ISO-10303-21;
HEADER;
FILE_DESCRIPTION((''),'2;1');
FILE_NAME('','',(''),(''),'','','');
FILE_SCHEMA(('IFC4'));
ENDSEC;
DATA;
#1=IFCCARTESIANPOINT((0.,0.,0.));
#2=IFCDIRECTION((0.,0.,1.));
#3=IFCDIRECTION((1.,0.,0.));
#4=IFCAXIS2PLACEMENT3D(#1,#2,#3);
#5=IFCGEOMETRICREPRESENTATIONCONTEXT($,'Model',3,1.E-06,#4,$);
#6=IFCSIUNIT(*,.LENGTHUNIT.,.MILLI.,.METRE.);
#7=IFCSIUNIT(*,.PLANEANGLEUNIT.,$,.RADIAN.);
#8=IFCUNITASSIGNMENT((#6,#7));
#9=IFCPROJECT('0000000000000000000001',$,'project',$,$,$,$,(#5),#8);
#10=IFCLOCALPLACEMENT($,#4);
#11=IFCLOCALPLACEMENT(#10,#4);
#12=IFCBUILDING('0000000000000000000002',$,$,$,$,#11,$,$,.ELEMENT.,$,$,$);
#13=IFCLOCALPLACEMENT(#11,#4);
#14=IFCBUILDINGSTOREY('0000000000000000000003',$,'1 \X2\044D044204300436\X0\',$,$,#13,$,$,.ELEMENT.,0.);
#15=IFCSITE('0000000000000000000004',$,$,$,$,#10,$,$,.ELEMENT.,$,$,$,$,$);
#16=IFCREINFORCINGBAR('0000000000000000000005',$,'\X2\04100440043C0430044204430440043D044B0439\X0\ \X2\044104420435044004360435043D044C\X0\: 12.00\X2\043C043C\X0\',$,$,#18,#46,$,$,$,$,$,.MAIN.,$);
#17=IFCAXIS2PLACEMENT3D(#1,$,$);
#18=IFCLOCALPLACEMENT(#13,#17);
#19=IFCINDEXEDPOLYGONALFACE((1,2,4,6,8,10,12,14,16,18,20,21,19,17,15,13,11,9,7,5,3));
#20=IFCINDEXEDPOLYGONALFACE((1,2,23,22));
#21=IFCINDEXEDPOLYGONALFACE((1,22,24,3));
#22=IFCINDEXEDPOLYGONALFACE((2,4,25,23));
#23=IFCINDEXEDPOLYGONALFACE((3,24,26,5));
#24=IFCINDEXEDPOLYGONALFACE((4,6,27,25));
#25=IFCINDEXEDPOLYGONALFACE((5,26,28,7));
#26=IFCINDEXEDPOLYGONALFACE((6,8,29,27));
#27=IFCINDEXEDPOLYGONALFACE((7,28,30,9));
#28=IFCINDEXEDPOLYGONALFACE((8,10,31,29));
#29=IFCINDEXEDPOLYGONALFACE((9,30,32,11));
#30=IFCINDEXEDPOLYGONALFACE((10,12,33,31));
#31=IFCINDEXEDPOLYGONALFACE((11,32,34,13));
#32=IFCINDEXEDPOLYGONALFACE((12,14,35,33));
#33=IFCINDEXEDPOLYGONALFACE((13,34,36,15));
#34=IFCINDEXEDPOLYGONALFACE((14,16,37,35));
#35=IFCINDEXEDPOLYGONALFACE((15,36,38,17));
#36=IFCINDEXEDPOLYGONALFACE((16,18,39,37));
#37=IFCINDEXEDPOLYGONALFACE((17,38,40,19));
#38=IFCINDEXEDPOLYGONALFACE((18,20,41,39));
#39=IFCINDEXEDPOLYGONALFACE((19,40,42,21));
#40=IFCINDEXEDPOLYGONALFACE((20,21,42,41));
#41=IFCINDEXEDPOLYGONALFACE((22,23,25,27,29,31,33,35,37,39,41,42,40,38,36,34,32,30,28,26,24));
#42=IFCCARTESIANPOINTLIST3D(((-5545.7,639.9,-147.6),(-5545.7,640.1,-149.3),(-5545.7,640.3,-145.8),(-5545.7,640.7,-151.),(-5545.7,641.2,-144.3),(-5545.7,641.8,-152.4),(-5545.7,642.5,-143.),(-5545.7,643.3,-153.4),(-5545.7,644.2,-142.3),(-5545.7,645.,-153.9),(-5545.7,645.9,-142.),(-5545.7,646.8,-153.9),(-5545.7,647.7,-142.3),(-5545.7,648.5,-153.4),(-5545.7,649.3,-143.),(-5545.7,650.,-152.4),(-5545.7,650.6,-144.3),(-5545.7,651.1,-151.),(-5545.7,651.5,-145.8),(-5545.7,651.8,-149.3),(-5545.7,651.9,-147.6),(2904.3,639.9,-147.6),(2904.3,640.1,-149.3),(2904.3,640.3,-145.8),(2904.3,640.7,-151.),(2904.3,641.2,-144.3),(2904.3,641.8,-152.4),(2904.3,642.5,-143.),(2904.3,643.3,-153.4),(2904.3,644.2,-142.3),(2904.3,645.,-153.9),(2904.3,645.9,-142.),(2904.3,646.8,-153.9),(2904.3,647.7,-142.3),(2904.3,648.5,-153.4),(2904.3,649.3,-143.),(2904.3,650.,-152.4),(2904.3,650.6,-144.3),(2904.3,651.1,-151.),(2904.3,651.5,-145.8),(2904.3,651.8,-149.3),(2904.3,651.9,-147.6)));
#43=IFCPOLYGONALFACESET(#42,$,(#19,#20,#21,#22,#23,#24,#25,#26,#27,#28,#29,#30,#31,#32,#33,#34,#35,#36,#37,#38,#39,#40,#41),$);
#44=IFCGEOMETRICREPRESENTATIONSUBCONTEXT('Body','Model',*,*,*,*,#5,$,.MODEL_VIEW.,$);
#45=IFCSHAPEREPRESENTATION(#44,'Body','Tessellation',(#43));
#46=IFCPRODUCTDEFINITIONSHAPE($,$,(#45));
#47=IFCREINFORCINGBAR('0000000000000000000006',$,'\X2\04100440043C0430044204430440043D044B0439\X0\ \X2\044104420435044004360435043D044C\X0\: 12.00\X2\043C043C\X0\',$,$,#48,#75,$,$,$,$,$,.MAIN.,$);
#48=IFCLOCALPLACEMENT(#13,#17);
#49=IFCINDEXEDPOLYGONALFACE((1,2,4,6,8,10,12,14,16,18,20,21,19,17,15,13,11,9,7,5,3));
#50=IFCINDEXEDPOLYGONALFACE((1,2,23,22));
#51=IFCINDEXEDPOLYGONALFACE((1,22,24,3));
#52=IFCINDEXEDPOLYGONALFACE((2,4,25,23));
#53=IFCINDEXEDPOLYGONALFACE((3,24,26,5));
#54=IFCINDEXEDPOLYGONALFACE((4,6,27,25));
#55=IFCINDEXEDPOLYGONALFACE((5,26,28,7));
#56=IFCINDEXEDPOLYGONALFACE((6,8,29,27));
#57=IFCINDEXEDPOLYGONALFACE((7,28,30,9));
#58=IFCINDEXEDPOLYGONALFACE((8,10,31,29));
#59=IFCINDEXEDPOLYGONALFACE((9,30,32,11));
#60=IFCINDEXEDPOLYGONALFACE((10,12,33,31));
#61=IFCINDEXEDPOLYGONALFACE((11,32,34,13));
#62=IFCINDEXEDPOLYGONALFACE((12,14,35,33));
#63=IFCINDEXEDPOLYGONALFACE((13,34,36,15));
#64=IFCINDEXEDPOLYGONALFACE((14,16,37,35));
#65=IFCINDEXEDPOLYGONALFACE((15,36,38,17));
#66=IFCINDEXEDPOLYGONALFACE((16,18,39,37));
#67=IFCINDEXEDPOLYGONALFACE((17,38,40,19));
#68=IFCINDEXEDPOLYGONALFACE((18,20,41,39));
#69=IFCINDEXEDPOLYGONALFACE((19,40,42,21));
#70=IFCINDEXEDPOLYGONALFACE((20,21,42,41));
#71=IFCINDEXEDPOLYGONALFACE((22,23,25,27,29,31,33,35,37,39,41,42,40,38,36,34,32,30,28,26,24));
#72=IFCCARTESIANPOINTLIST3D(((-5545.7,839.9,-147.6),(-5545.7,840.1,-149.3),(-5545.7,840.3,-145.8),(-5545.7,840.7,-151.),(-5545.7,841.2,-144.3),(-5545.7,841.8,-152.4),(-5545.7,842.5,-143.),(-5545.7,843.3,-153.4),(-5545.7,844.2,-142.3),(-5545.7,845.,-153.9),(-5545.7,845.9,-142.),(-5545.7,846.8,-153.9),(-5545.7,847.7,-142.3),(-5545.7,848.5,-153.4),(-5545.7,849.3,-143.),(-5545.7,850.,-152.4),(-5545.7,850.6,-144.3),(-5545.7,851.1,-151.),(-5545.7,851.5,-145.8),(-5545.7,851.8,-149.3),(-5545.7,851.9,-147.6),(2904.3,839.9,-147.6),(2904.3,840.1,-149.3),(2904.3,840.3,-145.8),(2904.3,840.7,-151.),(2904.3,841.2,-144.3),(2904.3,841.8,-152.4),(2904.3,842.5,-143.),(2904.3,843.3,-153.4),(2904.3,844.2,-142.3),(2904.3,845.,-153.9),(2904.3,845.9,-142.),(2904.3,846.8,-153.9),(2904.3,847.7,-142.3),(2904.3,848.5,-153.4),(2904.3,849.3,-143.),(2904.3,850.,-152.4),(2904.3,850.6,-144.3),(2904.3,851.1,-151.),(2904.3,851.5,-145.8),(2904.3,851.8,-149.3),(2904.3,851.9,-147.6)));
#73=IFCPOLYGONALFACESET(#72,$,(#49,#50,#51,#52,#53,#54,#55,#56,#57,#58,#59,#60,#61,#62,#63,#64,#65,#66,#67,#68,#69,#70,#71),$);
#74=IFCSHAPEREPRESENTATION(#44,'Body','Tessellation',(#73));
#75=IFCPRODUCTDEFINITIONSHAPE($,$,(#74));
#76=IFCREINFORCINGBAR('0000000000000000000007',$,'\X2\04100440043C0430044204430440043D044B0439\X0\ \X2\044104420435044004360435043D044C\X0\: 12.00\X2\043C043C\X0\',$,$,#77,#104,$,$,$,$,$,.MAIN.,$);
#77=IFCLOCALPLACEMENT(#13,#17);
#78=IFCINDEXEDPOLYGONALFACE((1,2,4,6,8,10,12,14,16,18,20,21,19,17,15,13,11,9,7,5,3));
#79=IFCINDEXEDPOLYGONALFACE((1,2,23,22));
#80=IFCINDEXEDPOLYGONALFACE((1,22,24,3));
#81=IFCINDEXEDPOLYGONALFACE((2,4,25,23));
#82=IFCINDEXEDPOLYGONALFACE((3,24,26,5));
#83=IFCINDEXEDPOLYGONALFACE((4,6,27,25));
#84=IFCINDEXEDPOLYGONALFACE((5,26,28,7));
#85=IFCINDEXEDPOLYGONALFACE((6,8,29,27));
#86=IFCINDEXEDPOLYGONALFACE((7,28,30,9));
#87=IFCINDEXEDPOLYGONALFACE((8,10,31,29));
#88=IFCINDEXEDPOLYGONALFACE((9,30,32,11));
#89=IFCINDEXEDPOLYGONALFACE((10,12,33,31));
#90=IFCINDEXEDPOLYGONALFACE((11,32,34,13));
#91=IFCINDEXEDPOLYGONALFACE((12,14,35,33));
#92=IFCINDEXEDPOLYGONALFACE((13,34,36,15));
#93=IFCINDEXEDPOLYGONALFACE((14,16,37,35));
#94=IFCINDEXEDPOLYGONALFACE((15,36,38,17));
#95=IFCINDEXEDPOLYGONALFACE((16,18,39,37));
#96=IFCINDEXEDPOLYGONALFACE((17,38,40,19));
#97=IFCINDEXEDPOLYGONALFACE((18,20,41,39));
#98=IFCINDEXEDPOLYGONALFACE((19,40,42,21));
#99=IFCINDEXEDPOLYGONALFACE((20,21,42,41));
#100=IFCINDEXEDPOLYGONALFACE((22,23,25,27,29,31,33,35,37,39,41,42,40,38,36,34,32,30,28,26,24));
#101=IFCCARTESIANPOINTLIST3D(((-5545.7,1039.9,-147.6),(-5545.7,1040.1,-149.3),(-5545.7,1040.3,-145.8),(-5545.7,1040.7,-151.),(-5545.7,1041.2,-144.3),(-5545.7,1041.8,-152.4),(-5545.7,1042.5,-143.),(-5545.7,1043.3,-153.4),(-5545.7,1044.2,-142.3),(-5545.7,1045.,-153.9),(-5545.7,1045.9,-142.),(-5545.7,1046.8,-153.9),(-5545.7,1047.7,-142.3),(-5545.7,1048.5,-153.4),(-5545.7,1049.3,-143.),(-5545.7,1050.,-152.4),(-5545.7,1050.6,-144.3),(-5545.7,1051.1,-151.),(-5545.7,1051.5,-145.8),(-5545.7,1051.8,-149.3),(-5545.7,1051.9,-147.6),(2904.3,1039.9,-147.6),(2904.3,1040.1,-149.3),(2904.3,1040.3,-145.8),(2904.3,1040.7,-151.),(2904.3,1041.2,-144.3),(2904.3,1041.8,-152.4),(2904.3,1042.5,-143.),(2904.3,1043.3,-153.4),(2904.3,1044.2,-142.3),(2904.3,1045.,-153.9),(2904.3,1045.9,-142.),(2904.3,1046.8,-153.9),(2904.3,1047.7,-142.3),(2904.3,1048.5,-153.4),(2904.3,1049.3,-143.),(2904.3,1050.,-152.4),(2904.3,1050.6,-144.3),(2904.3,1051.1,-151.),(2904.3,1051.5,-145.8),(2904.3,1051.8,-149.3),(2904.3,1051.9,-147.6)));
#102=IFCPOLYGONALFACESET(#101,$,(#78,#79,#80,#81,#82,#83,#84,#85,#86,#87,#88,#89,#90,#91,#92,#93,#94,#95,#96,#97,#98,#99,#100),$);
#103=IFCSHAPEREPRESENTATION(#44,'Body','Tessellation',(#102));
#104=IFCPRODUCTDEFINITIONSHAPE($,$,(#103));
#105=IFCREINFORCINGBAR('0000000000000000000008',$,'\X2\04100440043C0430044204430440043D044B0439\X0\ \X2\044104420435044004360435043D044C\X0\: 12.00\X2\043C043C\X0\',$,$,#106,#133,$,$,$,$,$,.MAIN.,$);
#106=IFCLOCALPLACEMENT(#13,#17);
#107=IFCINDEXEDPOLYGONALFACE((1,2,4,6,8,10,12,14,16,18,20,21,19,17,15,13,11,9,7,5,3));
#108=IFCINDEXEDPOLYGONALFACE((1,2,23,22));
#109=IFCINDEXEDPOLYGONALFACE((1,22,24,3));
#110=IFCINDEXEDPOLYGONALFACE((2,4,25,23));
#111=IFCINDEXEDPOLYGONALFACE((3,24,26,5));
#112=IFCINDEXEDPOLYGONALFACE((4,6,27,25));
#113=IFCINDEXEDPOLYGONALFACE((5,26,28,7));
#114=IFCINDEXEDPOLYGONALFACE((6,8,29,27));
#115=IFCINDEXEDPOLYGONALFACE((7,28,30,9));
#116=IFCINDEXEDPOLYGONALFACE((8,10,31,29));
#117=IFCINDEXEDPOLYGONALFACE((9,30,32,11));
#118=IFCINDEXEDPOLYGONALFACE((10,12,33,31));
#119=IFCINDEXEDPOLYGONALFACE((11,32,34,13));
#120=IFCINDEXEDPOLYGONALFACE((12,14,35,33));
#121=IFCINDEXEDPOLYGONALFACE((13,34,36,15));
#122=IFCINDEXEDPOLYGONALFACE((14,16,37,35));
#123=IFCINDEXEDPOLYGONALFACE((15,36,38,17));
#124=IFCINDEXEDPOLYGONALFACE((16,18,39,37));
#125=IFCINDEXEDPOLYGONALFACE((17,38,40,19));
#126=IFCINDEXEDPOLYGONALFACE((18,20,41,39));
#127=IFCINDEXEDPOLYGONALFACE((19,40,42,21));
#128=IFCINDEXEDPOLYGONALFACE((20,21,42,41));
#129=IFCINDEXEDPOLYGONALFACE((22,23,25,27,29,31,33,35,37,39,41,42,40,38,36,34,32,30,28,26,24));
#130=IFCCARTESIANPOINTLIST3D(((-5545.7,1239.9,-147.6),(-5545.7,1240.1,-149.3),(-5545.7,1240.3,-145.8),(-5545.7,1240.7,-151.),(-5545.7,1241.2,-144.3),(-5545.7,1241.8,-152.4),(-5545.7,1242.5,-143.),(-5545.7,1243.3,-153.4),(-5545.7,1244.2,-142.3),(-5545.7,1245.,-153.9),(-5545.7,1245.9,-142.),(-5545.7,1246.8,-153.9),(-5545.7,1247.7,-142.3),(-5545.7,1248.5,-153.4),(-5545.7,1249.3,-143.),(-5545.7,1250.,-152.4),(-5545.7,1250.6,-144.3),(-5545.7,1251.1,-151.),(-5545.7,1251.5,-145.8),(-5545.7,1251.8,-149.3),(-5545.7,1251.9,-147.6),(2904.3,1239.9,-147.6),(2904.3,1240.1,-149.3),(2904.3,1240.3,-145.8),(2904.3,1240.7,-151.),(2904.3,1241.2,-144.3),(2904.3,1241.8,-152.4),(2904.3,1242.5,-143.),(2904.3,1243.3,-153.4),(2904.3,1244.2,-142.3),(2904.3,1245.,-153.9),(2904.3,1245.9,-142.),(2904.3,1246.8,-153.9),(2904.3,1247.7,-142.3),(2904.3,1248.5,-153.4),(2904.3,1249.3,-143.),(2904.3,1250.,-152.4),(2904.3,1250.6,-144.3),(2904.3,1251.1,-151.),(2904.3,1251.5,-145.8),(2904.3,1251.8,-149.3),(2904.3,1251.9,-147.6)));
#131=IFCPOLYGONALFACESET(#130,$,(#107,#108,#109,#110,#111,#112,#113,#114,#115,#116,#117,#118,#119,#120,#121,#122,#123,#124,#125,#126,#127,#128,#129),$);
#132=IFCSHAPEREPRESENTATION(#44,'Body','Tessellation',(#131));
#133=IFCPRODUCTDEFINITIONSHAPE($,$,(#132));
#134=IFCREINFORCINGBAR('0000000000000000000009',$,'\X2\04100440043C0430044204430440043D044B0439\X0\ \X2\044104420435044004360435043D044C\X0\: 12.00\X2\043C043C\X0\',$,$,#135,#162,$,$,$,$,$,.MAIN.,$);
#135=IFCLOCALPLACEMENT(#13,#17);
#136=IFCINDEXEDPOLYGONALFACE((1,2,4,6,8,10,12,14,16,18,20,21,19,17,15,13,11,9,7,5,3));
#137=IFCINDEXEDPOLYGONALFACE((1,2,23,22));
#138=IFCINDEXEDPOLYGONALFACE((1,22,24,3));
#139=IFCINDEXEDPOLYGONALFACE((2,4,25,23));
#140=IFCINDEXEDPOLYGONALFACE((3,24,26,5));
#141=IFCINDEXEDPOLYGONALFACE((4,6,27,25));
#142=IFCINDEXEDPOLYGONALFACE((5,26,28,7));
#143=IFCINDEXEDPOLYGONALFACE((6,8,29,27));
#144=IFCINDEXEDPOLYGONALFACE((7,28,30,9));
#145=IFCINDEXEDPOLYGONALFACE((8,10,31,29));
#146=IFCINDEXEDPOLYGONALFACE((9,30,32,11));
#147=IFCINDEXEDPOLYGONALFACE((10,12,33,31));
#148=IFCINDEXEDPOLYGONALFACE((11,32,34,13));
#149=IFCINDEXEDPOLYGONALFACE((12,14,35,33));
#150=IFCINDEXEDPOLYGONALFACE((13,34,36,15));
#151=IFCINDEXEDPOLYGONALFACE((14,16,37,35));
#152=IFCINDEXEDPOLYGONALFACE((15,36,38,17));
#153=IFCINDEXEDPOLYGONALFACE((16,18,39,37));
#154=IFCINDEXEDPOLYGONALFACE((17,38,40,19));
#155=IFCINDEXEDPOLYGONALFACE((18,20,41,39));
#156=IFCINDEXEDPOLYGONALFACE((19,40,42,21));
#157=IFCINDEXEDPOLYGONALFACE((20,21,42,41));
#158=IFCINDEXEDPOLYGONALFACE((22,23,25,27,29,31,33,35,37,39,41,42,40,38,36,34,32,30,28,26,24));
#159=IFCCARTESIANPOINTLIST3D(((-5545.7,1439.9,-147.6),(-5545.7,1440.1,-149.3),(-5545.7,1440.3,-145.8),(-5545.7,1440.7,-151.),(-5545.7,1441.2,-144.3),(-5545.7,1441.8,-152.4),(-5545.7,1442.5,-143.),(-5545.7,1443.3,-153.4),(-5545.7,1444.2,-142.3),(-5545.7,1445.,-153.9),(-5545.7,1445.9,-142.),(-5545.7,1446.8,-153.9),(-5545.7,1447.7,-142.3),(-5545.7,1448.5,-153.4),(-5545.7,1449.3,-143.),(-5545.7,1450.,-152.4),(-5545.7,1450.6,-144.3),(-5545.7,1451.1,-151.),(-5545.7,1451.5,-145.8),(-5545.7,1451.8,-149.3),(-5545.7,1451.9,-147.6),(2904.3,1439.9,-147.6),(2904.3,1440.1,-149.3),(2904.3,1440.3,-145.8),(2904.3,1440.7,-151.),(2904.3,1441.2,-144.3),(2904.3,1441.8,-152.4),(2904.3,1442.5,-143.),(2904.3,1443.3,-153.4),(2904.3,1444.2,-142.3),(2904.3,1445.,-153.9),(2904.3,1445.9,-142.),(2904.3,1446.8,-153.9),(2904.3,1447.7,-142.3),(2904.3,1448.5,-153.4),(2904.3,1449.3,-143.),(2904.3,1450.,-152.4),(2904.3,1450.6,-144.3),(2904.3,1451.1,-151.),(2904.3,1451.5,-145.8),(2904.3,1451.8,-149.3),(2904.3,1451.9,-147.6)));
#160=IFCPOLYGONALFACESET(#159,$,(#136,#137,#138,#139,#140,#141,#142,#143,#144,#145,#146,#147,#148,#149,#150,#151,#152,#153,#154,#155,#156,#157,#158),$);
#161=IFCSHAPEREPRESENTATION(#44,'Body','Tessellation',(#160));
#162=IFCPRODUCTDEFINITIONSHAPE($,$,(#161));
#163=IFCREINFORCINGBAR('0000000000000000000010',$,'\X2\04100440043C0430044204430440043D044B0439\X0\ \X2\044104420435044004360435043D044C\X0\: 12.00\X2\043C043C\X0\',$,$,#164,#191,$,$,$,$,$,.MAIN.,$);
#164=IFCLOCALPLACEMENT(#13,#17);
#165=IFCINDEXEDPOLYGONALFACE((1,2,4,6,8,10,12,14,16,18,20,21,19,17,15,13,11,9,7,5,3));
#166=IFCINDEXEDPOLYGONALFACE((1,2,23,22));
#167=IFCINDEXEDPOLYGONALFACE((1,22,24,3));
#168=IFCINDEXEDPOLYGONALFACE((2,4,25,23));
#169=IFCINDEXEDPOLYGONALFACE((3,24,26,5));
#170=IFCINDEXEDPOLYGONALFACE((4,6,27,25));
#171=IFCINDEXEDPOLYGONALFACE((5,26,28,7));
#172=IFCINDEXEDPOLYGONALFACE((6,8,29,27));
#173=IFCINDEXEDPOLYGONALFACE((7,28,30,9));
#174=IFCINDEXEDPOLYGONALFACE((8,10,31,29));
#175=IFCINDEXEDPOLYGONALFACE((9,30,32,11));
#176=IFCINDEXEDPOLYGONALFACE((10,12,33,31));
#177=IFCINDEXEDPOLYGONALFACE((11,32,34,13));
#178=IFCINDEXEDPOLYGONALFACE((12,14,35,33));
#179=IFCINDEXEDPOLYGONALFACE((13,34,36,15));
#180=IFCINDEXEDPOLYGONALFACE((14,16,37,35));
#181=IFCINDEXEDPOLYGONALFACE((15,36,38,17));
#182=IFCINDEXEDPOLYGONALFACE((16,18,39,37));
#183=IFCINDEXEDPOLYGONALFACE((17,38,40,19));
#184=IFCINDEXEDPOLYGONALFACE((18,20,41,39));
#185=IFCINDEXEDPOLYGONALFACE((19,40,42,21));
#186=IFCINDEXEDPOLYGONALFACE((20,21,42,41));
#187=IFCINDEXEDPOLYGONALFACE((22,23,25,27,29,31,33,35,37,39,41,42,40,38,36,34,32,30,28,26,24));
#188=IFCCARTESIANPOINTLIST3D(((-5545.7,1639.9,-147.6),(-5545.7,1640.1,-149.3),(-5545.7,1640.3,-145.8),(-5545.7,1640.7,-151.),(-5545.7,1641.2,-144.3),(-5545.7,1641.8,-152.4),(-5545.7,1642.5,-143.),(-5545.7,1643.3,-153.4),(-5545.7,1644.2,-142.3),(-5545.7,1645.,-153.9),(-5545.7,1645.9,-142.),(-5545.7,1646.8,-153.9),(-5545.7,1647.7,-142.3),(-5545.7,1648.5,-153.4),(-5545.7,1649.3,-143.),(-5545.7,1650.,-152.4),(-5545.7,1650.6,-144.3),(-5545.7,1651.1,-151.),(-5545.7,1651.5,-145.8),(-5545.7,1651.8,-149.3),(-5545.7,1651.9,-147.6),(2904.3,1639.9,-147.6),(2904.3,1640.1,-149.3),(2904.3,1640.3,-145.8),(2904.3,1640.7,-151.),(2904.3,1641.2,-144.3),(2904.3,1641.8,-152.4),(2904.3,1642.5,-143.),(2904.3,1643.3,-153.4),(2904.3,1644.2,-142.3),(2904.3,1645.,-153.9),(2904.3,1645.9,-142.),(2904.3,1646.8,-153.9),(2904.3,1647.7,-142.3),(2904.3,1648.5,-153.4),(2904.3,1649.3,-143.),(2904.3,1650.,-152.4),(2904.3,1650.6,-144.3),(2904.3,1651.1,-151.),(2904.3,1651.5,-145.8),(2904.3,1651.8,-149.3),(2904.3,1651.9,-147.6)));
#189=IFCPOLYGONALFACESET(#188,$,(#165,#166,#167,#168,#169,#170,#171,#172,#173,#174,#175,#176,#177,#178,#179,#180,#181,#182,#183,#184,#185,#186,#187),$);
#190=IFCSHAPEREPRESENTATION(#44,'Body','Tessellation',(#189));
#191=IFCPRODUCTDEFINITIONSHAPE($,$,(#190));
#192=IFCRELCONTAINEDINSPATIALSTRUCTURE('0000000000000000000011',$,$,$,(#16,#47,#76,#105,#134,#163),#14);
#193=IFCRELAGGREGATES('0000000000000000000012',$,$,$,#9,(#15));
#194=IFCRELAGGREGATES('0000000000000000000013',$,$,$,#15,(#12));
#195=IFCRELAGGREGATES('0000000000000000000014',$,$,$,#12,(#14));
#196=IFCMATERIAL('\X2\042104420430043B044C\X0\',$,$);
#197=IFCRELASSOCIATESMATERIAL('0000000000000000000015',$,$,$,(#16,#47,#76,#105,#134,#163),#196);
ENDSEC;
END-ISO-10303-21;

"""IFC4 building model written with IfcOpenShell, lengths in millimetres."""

from ifc_helpers import new_model, entity, si_unit, origin_with_axes, place, context, subcontext, project, spatial, source, transform, mapped, material, element, save


model = new_model("IFC4")

# Units and contexts
model_context = context("Model", 3, precision=1e-06, world=origin_with_axes())
body_context = subcontext(model_context, "Body", "Model", "MODEL_VIEW")
ifc_project = project(units=[si_unit("LENGTHUNIT", "METRE", prefix="MILLI"), si_unit("PLANEANGLEUNIT", "RADIAN")], contexts=[model_context])

# Site, building, storey
site_placement = place(None, origin_with_axes())
site = spatial("IfcSite", under=ifc_project, at=site_placement, CompositionType="ELEMENT")
building_placement = place(site_placement, origin_with_axes())
building = spatial("IfcBuilding", under=site, at=building_placement, CompositionType="ELEMENT")
storey_placement = place(building_placement, origin_with_axes())
storey = spatial("IfcBuildingStorey", under=building, at=storey_placement, Name="1 этаж", CompositionType="ELEMENT", Elevation=0.0)

# Reinforcing bars
ifc_material = material(Name="Сталь")
shared_shape = source(origin_with_axes(), body_context, "Body", "AdvancedSweptSolid", [
    entity("IfcSweptDiskSolid", entity("IfcIndexedPolyCurve", entity("IfcCartesianPointList3D", [[0.0, 0.0, 0.0], [8450.0, 0.0, 0.0]]), [entity("IfcLineIndex", [1, 2])]), 6.0),
])
reinforcing_bar_1_placement = place(storey_placement, origin_with_axes())
element("IfcReinforcingBar", 1, at=reinforcing_bar_1_placement, inside=storey, material=ifc_material, Name="Арматурный стержень: 12.00мм", PredefinedType="MAIN", context=body_context, shape_type="MappedRepresentation", body=[
    mapped(shared_shape, transform((-5545.7, 645.9, -148.0), x_axis=(1.0, 0.0, 0.0), y_axis=(0.0, 1.0, 0.0), z_axis=(0.0, 0.0, 1.0), scale=1.0)),
])
reinforcing_bar_2_placement = place(storey_placement, origin_with_axes())
element("IfcReinforcingBar", 2, at=reinforcing_bar_2_placement, inside=storey, material=ifc_material, Name="Арматурный стержень: 12.00мм", PredefinedType="MAIN", context=body_context, shape_type="MappedRepresentation", body=[
    mapped(shared_shape, transform((-5545.7, 845.9, -148.0), x_axis=(1.0, 0.0, 0.0), y_axis=(0.0, 1.0, 0.0), z_axis=(0.0, 0.0, 1.0), scale=1.0)),
])
reinforcing_bar_3_placement = place(storey_placement, origin_with_axes())
element("IfcReinforcingBar", 3, at=reinforcing_bar_3_placement, inside=storey, material=ifc_material, Name="Арматурный стержень: 12.00мм", PredefinedType="MAIN", context=body_context, shape_type="MappedRepresentation", body=[
    mapped(shared_shape, transform((-5545.7, 1045.9, -148.0), x_axis=(1.0, 0.0, 0.0), y_axis=(0.0, 1.0, 0.0), z_axis=(0.0, 0.0, 1.0), scale=1.0)),
])
reinforcing_bar_4_placement = place(storey_placement, origin_with_axes())
element("IfcReinforcingBar", 4, at=reinforcing_bar_4_placement, inside=storey, material=ifc_material, Name="Арматурный стержень: 12.00мм", PredefinedType="MAIN", context=body_context, shape_type="MappedRepresentation", body=[
    mapped(shared_shape, transform((-5545.7, 1245.9, -148.0), x_axis=(1.0, 0.0, 0.0), y_axis=(0.0, 1.0, 0.0), z_axis=(0.0, 0.0, 1.0), scale=1.0)),
])
reinforcing_bar_5_placement = place(storey_placement, origin_with_axes())
element("IfcReinforcingBar", 5, at=reinforcing_bar_5_placement, inside=storey, material=ifc_material, Name="Арматурный стержень: 12.00мм", PredefinedType="MAIN", context=body_context, shape_type="MappedRepresentation", body=[
    mapped(shared_shape, transform((-5545.7, 1445.9, -148.0), x_axis=(1.0, 0.0, 0.0), y_axis=(0.0, 1.0, 0.0), z_axis=(0.0, 0.0, 1.0), scale=1.0)),
])
reinforcing_bar_6_placement = place(storey_placement, origin_with_axes())
element("IfcReinforcingBar", 6, at=reinforcing_bar_6_placement, inside=storey, material=ifc_material, Name="Арматурный стержень: 12.00мм", PredefinedType="MAIN", context=body_context, shape_type="MappedRepresentation", body=[
    mapped(shared_shape, transform((-5545.7, 1645.9, -148.0), x_axis=(1.0, 0.0, 0.0), y_axis=(0.0, 1.0, 0.0), z_axis=(0.0, 0.0, 1.0), scale=1.0)),
])

save(model, "model.ifc")
